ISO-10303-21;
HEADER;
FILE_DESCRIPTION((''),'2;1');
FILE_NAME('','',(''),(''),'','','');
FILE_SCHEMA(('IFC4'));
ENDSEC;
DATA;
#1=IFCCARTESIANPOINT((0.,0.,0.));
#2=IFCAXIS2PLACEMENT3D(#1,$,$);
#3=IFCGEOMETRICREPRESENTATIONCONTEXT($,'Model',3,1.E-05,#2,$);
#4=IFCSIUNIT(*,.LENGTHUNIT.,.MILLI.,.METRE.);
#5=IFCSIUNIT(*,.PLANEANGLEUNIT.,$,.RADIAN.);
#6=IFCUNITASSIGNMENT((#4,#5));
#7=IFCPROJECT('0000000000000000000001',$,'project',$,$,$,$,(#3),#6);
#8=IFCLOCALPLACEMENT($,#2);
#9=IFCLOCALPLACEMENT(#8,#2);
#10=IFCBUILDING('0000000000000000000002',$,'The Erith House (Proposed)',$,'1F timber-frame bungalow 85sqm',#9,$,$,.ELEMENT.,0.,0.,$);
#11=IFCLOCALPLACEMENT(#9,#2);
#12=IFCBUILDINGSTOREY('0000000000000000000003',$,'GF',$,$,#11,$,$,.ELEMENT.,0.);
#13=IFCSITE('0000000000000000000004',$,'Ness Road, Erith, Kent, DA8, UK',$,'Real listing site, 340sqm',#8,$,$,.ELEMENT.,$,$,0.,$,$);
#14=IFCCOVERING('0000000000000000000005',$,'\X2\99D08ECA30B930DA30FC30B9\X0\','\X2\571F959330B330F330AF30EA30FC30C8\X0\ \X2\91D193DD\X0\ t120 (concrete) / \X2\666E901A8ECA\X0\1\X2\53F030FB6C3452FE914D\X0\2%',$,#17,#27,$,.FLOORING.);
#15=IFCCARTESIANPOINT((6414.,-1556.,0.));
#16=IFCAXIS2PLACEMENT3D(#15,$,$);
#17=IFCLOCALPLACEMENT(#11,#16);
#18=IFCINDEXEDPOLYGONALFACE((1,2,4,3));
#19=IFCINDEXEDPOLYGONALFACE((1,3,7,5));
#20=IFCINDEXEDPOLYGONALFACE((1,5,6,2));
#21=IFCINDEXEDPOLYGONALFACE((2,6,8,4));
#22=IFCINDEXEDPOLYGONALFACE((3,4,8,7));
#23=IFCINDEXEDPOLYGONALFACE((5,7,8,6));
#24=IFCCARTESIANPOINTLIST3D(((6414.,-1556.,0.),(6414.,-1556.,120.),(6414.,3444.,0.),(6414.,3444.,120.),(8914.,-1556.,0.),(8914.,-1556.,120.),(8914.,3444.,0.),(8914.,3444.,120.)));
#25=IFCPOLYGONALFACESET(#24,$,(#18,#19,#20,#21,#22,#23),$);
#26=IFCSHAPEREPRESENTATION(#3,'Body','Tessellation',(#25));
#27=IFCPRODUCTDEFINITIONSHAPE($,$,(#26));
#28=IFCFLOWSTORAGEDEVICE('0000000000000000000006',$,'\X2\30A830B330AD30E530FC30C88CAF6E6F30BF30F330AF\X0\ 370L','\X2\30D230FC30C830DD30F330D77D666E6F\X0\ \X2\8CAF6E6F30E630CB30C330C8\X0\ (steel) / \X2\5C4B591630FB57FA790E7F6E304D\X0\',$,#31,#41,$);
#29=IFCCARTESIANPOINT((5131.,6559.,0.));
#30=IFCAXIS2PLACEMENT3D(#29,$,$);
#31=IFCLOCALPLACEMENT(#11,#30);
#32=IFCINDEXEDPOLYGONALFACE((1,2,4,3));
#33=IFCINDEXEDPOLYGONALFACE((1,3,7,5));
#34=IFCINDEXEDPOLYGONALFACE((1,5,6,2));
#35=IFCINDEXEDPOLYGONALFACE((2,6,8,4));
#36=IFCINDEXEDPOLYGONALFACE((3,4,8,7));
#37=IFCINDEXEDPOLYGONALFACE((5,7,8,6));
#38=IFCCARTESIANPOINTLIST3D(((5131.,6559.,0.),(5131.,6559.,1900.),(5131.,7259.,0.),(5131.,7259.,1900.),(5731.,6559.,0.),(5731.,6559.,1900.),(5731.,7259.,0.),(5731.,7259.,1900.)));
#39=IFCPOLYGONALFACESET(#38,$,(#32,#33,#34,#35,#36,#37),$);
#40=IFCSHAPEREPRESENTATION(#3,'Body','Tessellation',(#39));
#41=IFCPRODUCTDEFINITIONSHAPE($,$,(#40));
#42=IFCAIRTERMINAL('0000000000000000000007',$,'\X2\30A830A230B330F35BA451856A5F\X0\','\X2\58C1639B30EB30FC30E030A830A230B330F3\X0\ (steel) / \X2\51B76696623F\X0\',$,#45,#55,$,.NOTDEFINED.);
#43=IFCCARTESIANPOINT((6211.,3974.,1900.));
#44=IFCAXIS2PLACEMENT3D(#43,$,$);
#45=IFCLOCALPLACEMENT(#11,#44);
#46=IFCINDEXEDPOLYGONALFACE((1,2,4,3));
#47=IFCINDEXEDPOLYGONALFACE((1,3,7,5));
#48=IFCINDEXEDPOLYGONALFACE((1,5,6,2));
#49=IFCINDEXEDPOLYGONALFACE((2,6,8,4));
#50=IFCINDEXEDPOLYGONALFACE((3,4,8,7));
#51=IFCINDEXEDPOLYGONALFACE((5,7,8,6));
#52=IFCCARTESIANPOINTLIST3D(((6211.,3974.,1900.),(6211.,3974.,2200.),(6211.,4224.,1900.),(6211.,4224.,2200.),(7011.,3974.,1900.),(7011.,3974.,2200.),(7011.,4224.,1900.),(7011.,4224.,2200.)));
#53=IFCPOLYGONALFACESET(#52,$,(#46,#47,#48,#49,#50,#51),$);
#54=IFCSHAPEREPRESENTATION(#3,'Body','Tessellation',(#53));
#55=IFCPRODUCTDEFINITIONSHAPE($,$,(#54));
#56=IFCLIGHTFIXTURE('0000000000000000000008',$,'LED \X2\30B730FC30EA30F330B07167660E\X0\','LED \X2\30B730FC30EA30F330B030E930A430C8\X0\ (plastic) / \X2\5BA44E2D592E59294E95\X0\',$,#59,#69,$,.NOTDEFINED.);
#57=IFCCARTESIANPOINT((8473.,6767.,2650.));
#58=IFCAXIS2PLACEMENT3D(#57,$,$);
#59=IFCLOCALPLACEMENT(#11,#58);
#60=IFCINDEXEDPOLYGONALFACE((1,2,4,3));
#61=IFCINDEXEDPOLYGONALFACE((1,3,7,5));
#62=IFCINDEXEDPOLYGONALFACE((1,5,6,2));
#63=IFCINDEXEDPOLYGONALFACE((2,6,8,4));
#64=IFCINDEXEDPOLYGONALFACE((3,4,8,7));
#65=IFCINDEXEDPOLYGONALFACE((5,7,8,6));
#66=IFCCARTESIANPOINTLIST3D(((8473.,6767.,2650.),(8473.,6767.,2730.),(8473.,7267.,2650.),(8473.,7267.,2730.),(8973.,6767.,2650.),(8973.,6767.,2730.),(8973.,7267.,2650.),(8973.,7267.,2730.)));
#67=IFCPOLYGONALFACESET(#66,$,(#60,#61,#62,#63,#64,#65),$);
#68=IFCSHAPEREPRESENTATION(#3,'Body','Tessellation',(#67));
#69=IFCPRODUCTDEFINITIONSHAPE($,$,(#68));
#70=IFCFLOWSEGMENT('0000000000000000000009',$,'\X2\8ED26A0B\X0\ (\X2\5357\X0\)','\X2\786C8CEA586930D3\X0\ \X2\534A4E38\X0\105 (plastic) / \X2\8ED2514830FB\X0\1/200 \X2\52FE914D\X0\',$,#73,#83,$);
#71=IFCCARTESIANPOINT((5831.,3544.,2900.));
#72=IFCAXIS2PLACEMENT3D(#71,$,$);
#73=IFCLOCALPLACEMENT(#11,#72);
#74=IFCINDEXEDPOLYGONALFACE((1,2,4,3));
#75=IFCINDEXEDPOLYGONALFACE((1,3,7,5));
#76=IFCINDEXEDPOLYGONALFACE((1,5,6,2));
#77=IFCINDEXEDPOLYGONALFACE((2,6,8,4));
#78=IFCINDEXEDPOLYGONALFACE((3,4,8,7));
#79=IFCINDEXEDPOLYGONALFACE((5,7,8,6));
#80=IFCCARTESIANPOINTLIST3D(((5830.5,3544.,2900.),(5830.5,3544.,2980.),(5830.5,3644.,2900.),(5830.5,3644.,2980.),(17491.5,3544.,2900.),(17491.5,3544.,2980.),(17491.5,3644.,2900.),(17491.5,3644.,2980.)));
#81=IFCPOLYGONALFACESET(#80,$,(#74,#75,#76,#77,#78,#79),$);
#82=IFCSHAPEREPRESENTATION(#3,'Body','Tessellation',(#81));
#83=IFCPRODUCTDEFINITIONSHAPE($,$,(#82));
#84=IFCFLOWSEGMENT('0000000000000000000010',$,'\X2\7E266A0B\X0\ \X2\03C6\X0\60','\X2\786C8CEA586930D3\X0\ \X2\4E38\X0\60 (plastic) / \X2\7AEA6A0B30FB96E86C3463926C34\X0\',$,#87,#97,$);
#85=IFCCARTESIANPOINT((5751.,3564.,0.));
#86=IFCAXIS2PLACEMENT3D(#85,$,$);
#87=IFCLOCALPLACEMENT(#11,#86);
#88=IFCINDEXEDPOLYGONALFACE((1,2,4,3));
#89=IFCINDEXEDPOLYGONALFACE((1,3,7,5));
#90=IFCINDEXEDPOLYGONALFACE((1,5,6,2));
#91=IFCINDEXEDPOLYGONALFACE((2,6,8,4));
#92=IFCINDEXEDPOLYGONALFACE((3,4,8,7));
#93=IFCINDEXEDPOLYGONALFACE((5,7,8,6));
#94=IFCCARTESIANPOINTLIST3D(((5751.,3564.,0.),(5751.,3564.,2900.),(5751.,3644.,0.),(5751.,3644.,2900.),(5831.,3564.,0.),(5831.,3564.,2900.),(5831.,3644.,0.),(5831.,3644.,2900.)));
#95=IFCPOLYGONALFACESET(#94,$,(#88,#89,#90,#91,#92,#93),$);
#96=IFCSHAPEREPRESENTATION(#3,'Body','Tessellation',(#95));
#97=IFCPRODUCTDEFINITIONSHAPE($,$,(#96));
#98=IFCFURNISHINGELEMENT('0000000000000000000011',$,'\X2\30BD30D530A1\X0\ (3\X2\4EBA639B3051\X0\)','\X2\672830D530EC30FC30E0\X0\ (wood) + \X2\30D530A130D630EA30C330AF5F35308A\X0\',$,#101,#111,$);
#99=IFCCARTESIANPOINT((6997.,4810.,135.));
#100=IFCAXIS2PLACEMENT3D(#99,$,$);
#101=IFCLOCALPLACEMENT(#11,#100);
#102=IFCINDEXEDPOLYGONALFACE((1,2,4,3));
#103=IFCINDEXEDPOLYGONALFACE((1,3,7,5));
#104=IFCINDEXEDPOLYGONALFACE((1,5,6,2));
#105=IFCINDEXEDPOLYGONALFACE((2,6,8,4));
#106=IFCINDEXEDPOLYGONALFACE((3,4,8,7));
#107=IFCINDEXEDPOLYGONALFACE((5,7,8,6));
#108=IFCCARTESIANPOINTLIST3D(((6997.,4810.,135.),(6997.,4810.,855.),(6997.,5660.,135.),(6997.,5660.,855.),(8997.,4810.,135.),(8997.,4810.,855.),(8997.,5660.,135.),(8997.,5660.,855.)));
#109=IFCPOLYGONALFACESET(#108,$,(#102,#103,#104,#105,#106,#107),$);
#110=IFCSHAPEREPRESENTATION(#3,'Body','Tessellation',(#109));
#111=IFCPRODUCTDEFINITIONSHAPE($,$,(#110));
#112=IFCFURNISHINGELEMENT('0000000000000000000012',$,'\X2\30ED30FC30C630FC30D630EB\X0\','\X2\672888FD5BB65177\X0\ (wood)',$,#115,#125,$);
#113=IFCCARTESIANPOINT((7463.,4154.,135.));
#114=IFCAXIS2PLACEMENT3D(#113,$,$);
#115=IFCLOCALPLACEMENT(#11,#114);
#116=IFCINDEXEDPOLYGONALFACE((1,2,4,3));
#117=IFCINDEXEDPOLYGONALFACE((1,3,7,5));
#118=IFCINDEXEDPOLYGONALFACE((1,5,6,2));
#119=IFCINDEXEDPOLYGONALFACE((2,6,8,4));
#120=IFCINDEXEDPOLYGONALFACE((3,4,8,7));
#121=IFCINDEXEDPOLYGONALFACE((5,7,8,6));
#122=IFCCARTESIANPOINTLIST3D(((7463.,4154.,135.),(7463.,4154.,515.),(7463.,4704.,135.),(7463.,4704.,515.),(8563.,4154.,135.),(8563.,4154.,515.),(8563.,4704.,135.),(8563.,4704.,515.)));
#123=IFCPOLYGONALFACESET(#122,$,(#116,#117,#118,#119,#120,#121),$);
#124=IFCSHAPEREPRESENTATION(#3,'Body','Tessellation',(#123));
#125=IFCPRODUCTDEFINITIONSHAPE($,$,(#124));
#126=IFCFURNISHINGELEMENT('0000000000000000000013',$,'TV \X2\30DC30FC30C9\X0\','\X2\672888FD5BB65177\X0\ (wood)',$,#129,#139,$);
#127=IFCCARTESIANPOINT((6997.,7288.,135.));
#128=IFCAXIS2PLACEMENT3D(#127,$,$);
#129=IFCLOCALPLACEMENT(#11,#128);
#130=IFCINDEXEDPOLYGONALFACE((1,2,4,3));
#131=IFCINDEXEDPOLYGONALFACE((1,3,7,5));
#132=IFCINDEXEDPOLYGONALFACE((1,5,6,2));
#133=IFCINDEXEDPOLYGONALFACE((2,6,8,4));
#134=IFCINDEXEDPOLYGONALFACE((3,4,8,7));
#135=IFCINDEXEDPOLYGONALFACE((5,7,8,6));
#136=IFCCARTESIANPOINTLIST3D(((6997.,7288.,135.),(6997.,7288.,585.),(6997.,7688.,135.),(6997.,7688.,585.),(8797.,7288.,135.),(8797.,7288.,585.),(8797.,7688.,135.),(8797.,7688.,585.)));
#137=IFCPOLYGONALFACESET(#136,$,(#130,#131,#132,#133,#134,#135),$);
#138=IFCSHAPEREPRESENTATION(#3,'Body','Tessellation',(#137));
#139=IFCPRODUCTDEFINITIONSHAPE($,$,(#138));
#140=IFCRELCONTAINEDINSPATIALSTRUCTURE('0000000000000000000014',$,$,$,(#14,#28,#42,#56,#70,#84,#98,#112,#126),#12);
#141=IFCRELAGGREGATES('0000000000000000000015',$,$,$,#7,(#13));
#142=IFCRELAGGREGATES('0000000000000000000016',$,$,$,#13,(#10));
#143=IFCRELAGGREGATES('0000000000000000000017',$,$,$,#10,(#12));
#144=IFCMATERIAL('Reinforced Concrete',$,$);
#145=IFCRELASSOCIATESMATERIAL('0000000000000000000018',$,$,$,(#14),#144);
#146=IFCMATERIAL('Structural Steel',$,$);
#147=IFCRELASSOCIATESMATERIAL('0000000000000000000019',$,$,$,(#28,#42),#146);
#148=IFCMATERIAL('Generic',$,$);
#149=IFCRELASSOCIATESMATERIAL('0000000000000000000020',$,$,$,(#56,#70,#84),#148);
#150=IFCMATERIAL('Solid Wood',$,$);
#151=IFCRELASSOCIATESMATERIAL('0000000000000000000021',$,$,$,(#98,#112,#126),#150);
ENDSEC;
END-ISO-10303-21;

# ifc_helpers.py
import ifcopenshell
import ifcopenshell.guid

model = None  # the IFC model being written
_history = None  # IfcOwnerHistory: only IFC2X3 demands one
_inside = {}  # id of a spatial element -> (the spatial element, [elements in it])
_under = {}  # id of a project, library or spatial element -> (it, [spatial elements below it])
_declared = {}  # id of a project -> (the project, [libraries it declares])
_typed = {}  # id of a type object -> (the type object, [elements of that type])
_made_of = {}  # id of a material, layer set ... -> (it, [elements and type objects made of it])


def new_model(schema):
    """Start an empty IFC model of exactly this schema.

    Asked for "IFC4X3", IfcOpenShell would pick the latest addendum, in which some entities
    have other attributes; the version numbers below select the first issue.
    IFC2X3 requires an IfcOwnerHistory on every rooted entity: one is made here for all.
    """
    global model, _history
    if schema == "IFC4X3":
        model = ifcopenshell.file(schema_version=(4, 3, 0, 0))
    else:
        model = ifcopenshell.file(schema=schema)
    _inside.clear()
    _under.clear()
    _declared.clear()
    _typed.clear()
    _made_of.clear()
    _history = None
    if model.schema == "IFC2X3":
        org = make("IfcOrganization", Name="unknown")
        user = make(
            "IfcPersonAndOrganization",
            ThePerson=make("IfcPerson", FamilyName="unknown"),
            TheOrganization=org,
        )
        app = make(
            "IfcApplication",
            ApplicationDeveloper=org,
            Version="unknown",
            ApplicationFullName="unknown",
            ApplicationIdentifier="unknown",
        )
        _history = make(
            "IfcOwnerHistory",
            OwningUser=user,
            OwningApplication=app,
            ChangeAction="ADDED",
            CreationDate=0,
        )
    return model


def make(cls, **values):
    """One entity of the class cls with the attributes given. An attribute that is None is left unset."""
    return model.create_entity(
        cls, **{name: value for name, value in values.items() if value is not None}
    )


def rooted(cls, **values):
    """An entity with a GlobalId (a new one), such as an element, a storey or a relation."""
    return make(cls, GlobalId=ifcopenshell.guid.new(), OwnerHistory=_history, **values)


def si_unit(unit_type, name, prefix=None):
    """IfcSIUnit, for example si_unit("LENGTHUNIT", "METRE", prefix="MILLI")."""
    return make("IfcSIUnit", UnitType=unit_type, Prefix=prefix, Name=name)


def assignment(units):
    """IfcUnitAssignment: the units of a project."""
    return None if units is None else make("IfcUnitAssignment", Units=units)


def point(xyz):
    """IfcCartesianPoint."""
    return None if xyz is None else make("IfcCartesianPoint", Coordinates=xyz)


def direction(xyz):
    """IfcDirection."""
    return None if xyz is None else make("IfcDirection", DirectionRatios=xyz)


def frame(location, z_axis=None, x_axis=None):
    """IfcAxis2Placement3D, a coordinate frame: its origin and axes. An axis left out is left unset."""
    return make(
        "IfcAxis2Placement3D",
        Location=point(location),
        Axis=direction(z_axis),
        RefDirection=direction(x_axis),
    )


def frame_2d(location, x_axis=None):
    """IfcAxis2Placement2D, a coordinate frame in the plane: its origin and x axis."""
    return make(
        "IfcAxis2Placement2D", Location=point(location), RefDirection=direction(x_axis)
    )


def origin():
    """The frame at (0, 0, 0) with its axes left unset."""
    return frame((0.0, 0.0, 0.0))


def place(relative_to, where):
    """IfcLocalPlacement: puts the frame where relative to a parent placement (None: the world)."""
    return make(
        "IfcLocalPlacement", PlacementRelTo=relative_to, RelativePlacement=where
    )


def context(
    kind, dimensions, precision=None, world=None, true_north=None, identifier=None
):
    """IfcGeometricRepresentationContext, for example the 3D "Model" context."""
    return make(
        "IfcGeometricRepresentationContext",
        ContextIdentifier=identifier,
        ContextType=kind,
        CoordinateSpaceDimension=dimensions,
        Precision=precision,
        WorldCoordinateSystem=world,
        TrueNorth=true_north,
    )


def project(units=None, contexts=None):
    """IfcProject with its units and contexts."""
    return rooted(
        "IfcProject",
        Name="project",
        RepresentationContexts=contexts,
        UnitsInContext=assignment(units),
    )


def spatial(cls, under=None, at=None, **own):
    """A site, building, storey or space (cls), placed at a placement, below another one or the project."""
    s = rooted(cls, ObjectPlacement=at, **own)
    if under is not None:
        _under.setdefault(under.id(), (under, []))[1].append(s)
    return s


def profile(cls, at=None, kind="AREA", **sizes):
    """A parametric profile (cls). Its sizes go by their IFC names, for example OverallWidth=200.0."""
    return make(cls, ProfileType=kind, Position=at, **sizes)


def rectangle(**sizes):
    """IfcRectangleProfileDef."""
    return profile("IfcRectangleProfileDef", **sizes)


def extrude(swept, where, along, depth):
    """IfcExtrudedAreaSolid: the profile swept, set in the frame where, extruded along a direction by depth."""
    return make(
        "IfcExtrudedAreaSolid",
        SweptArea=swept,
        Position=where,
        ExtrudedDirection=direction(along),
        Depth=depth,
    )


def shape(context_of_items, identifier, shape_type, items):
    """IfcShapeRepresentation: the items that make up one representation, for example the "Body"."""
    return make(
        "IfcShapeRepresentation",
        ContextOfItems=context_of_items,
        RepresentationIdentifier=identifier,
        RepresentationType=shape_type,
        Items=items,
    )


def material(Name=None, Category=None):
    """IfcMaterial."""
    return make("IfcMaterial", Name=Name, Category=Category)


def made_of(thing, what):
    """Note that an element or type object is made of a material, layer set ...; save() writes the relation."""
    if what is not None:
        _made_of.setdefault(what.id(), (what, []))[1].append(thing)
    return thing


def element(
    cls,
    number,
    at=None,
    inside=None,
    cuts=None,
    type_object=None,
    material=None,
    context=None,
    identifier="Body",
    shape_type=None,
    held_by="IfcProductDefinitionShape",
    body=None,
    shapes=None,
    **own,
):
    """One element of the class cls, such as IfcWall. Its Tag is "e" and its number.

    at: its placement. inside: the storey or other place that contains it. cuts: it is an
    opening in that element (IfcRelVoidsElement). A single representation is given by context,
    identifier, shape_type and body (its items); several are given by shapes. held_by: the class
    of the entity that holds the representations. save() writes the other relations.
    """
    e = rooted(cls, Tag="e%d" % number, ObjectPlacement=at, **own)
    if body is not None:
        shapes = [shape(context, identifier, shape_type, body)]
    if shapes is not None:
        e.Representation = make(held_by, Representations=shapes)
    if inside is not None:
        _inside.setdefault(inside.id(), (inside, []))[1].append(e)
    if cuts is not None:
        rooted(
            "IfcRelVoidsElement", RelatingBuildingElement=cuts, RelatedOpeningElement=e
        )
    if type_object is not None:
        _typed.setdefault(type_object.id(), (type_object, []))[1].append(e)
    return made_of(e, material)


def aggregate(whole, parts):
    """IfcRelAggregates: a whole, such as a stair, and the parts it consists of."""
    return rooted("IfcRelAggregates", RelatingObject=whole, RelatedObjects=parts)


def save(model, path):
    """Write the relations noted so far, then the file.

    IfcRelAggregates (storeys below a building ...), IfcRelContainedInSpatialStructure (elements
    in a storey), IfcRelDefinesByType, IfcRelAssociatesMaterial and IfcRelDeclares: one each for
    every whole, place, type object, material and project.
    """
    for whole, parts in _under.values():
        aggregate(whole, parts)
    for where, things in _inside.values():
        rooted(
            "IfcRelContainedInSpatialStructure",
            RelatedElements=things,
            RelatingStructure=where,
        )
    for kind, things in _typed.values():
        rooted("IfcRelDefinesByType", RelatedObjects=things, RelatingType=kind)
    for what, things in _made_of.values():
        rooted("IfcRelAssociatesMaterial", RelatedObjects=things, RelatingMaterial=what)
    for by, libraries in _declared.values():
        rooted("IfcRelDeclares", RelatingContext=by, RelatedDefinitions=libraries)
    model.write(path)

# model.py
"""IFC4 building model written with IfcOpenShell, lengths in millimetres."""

from ifc_helpers import new_model, si_unit, frame, frame_2d, origin, place, context, project, spatial, rectangle, extrude, material, element, save


model = new_model("IFC4")

# Units and contexts
model_context = context("Model", 3, precision=1e-05, world=origin())
ifc_project = project(units=[si_unit("LENGTHUNIT", "METRE", prefix="MILLI"), si_unit("PLANEANGLEUNIT", "RADIAN")], contexts=[model_context])

# Site, building, storey
site_placement = place(None, origin())
site = spatial("IfcSite", under=ifc_project, at=site_placement, Name="Ness Road, Erith, Kent, DA8, UK", ObjectType="Real listing site, 340sqm", CompositionType="ELEMENT", RefElevation=0.0)
building_placement = place(site_placement, origin())
building = spatial("IfcBuilding", under=site, at=building_placement, Name="The Erith House (Proposed)", ObjectType="1F timber-frame bungalow 85sqm", CompositionType="ELEMENT", ElevationOfRefHeight=0.0, ElevationOfTerrain=0.0)
storey_placement = place(building_placement, origin())
storey = spatial("IfcBuildingStorey", under=building, at=storey_placement, Name="GF", CompositionType="ELEMENT", Elevation=0.0)

# Shared definitions
ifc_material_1 = material(Name="Solid Wood")

# Shared definitions
ifc_material_2 = material(Name="Reinforced Concrete")

# Shared definitions
ifc_material_3 = material(Name="Structural Steel")

# Covering
ifc_material_4 = material(Name="Generic")
covering_1_placement = place(storey_placement, frame((6414.0, -1556.0, 0.0)))
element("IfcCovering", 1, at=covering_1_placement, inside=storey, material=ifc_material_2, Name="駐車スペース", Description="土間コンクリート 金鏝 t120 (concrete) / 普通車1台・水勾配2%", PredefinedType="FLOORING", context=model_context, shape_type="SweptSolid", body=[
    extrude(rectangle(XDim=2500.0, YDim=5000.0, at=frame_2d((1250.0, 2500.0))), frame((6414.0, -1556.0, 0.0)), (0.0, 0.0, 1.0), 120.0),
])

# Flow storage device
flow_storage_device_placement = place(storey_placement, frame((5131.0, 6559.0, 0.0)))
element("IfcFlowStorageDevice", 2, at=flow_storage_device_placement, inside=storey, material=ifc_material_3, Name="エコキュート貯湯タンク 370L", Description="ヒートポンプ給湯 貯湯ユニット (steel) / 屋外・基礎置き", context=model_context, shape_type="SweptSolid", body=[
    extrude(rectangle(XDim=600.0, YDim=700.0, at=frame_2d((300.0, 350.0))), frame((5131.0, 6559.0, 0.0)), (0.0, 0.0, 1.0), 1900.0),
])

# Air terminal
air_terminal_placement = place(storey_placement, frame((6211.0, 3974.0, 1900.0)))
element("IfcAirTerminal", 3, at=air_terminal_placement, inside=storey, material=ifc_material_3, Name="エアコン室内機", Description="壁掛ルームエアコン (steel) / 冷暖房", PredefinedType="NOTDEFINED", context=model_context, shape_type="SweptSolid", body=[
    extrude(rectangle(XDim=800.0, YDim=250.0, at=frame_2d((400.0, 125.0))), frame((6211.0, 3974.0, 1900.0)), (0.0, 0.0, 1.0), 300.0),
])

# Light fixture
light_fixture_placement = place(storey_placement, frame((8473.0, 6767.0, 2650.0)))
element("IfcLightFixture", 4, at=light_fixture_placement, inside=storey, material=ifc_material_4, Name="LED シーリング照明", Description="LED シーリングライト (plastic) / 室中央天井", PredefinedType="NOTDEFINED", context=model_context, shape_type="SweptSolid", body=[
    extrude(rectangle(XDim=500.0, YDim=500.0, at=frame_2d((250.0, 250.0))), frame((8473.0, 6767.0, 2650.0)), (0.0, 0.0, 1.0), 80.0),
])

# Flow segments
flow_segment_1_placement = place(storey_placement, frame((5831.0, 3544.0, 2900.0)))
element("IfcFlowSegment", 5, at=flow_segment_1_placement, inside=storey, material=ifc_material_4, Name="軒樋 (南)", Description="硬質塩ビ 半丸105 (plastic) / 軒先・1/200 勾配", context=model_context, shape_type="SweptSolid", body=[
    extrude(rectangle(XDim=11661.0, YDim=100.0, at=frame_2d((5830.0, 50.0))), frame((5831.0, 3544.0, 2900.0)), (0.0, 0.0, 1.0), 80.0),
])
flow_segment_2_placement = place(storey_placement, frame((5751.0, 3564.0, 0.0)))
element("IfcFlowSegment", 6, at=flow_segment_2_placement, inside=storey, material=ifc_material_4, Name="縦樋 φ60", Description="硬質塩ビ 丸60 (plastic) / 竪樋・雨水排水", context=model_context, shape_type="SweptSolid", body=[
    extrude(rectangle(XDim=80.0, YDim=80.0, at=frame_2d((40.0, 40.0))), frame((5751.0, 3564.0, 0.0)), (0.0, 0.0, 1.0), 2900.0),
])

# Furnishing elements
furnishing_1_placement = place(storey_placement, frame((6997.0, 4810.0, 135.0)))
element("IfcFurnishingElement", 7, at=furnishing_1_placement, inside=storey, material=ifc_material_1, Name="ソファ (3人掛け)", Description="木フレーム (wood) + ファブリック張り", context=model_context, shape_type="SweptSolid", body=[
    extrude(rectangle(XDim=2000.0, YDim=850.0, at=frame_2d((1000.0, 425.0))), frame((6997.0, 4810.0, 135.0)), (0.0, 0.0, 1.0), 720.0),
])
furnishing_2_placement = place(storey_placement, frame((7463.0, 4154.0, 135.0)))
element("IfcFurnishingElement", 8, at=furnishing_2_placement, inside=storey, material=ifc_material_1, Name="ローテーブル", Description="木製家具 (wood)", context=model_context, shape_type="SweptSolid", body=[
    extrude(rectangle(XDim=1100.0, YDim=550.0, at=frame_2d((550.0, 275.0))), frame((7463.0, 4154.0, 135.0)), (0.0, 0.0, 1.0), 380.0),
])
furnishing_3_placement = place(storey_placement, frame((6997.0, 7288.0, 135.0)))
element("IfcFurnishingElement", 9, at=furnishing_3_placement, inside=storey, material=ifc_material_1, Name="TV ボード", Description="木製家具 (wood)", context=model_context, shape_type="SweptSolid", body=[
    extrude(rectangle(XDim=1800.0, YDim=400.0, at=frame_2d((900.0, 200.0))), frame((6997.0, 7288.0, 135.0)), (0.0, 0.0, 1.0), 450.0),
])

save(model, "model.ifc")
